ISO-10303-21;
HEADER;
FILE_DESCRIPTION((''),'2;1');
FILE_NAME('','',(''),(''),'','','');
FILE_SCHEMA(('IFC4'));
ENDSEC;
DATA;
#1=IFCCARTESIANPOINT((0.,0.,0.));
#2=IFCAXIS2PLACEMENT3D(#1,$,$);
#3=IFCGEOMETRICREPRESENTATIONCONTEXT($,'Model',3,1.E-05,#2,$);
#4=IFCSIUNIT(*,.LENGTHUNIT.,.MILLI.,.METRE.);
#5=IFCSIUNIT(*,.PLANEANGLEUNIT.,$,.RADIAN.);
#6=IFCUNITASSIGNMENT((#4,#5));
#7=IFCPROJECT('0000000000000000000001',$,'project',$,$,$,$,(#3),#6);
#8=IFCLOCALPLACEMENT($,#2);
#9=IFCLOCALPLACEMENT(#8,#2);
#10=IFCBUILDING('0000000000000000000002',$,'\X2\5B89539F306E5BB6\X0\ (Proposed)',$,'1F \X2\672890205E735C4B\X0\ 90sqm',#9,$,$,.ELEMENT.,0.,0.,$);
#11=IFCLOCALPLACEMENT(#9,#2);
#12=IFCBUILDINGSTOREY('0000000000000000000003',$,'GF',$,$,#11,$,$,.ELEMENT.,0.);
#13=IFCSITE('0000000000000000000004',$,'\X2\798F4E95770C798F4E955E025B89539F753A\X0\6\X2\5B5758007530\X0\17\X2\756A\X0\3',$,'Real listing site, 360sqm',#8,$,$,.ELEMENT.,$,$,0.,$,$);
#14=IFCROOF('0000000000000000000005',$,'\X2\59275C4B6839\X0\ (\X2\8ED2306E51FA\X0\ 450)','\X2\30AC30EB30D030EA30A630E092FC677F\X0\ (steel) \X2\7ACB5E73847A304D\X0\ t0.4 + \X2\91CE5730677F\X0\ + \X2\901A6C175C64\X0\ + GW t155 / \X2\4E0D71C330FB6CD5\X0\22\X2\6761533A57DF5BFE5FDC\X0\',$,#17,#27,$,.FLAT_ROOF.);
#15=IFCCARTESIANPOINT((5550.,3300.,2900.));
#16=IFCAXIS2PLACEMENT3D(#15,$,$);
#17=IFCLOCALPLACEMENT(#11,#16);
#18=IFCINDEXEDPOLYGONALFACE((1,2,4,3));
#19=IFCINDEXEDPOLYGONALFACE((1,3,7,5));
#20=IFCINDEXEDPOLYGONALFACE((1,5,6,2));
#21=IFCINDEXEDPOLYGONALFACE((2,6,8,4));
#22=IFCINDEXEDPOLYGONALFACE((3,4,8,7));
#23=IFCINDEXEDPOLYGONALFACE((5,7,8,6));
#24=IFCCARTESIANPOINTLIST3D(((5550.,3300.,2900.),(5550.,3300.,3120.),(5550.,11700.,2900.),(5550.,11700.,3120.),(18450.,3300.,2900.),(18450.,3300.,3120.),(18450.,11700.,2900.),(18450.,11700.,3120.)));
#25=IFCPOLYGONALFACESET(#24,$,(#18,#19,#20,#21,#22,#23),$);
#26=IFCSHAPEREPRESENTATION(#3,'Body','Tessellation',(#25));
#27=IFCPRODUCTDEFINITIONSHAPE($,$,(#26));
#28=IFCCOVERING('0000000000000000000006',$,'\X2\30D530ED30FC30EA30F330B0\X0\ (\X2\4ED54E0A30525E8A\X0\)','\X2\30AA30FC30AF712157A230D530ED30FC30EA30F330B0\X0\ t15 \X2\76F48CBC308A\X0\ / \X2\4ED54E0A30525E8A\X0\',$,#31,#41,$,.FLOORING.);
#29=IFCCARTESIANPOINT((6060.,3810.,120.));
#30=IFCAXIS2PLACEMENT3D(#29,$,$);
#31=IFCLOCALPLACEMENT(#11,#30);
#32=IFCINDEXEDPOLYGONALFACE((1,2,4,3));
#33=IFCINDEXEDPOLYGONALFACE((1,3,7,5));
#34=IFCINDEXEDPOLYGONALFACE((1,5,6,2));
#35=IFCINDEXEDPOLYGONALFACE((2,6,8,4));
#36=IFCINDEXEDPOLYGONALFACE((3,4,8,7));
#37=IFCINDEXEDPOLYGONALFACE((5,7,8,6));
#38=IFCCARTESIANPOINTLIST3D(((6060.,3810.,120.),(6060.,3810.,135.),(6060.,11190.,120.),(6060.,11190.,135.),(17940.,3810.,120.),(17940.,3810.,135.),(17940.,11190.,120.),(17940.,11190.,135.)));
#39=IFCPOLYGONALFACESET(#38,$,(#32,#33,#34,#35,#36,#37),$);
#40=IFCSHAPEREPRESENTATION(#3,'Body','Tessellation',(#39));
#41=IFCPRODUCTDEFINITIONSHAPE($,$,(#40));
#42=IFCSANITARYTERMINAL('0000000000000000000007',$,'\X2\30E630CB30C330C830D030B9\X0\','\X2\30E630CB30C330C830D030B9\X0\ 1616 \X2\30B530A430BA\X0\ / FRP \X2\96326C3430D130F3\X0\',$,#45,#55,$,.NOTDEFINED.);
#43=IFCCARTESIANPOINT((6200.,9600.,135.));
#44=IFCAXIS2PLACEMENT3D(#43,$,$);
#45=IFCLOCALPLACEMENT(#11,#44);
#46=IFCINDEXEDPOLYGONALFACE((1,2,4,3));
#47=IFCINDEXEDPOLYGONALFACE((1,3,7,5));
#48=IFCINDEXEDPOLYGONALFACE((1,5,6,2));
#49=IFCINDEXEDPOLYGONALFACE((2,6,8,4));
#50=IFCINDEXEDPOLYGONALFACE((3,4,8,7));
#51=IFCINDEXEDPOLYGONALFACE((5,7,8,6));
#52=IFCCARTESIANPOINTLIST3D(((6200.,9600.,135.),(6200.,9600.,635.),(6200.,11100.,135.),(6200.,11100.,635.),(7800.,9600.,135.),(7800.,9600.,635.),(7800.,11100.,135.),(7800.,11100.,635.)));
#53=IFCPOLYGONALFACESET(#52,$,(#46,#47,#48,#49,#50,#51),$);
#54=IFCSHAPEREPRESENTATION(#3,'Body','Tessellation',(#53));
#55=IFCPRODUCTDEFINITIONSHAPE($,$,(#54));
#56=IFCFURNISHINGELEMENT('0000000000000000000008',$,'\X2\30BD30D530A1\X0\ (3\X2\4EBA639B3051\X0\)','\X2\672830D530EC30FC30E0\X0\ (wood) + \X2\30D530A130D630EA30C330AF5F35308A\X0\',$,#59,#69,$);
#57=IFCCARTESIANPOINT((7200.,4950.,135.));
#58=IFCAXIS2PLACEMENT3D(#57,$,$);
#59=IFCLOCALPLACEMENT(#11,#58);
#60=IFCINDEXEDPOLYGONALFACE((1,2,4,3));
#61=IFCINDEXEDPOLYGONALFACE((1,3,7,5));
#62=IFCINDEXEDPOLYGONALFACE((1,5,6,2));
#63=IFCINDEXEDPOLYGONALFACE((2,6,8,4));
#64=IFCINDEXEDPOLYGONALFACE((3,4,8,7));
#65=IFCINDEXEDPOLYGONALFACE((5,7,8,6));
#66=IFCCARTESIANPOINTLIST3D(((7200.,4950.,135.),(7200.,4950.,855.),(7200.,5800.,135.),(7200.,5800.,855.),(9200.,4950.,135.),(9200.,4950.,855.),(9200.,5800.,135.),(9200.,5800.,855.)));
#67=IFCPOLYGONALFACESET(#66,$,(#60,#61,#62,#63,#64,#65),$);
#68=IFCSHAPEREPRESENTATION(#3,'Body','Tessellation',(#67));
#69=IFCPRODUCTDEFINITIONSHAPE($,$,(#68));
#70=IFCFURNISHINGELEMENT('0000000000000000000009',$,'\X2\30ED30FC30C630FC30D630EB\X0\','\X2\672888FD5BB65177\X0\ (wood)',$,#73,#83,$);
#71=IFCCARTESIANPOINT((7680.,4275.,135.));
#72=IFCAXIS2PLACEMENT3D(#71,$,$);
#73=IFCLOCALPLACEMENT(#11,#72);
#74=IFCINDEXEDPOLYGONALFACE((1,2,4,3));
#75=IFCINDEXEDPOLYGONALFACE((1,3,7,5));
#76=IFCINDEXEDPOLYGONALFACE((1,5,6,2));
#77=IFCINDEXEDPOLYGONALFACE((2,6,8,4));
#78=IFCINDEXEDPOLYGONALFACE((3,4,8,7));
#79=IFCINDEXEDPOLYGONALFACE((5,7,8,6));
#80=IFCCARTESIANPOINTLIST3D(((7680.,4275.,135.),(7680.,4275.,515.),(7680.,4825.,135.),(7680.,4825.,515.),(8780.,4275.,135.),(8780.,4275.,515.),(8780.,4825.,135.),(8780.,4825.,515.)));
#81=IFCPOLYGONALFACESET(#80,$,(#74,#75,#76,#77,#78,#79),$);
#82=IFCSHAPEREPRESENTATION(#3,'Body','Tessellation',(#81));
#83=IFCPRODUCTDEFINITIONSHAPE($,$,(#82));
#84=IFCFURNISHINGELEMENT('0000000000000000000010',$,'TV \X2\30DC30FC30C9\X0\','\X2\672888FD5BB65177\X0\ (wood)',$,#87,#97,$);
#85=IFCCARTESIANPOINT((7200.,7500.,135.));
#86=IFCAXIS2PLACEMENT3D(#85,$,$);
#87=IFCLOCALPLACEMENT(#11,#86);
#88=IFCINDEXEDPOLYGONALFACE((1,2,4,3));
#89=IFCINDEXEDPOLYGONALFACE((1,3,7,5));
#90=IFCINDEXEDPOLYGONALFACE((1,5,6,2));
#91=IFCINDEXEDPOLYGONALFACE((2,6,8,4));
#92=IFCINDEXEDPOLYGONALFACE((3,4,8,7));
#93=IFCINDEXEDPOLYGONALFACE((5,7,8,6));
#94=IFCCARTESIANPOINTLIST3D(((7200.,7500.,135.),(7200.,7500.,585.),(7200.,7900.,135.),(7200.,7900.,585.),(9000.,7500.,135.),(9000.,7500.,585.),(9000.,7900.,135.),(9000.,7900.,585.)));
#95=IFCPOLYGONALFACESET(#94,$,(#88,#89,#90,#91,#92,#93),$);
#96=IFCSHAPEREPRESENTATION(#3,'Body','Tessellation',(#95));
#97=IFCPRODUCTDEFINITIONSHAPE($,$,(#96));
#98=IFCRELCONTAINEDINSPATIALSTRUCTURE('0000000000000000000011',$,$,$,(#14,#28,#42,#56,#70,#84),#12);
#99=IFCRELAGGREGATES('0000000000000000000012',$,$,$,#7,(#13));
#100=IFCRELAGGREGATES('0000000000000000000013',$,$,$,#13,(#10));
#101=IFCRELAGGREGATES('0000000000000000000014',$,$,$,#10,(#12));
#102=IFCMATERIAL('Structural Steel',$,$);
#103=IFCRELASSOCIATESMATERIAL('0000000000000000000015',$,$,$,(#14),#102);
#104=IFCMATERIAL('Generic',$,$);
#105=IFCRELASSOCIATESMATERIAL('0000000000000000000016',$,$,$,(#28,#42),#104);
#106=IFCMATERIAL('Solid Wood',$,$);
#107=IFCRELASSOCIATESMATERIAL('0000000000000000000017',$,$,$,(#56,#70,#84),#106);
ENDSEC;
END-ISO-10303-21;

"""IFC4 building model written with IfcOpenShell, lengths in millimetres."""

from ifc_helpers import new_model, si_unit, frame, frame_2d, origin, place, context, project, spatial, rectangle, extrude, material, element, save


model = new_model("IFC4")

# Units and contexts
model_context = context("Model", 3, precision=1e-05, world=origin())
ifc_project = project(units=[si_unit("LENGTHUNIT", "METRE", prefix="MILLI"), si_unit("PLANEANGLEUNIT", "RADIAN")], contexts=[model_context])

# Site, building, storey
site_placement = place(None, origin())
site = spatial("IfcSite", under=ifc_project, at=site_placement, Name="福井県福井市安原町6字堀田17番3", ObjectType="Real listing site, 360sqm", CompositionType="ELEMENT", RefElevation=0.0)
building_placement = place(site_placement, origin())
building = spatial("IfcBuilding", under=site, at=building_placement, Name="安原の家 (Proposed)", ObjectType="1F 木造平屋 90sqm", CompositionType="ELEMENT", ElevationOfRefHeight=0.0, ElevationOfTerrain=0.0)
storey_placement = place(building_placement, origin())
storey = spatial("IfcBuildingStorey", under=building, at=storey_placement, Name="GF", CompositionType="ELEMENT", Elevation=0.0)

# Shared definitions
ifc_material_1 = material(Name="Solid Wood")

# Roof
ifc_material_2 = material(Name="Structural Steel")
roof_placement = place(storey_placement, frame((5550.0, 3300.0, 2900.0)))
element("IfcRoof", 1, at=roof_placement, inside=storey, material=ifc_material_2, Name="大屋根 (軒の出 450)", Description="ガルバリウム鋼板 (steel) 立平葺き t0.4 + 野地板 + 通気層 + GW t155 / 不燃・法22条区域対応", PredefinedType="FLAT_ROOF", context=model_context, shape_type="SweptSolid", body=[
    extrude(rectangle(XDim=12900.0, YDim=8400.0, at=frame_2d((6450.0, 4200.0))), frame((5550.0, 3300.0, 2900.0)), (0.0, 0.0, 1.0), 220.0),
])

# Covering
ifc_material_3 = material(Name="Generic")
covering_placement = place(storey_placement, frame((6060.0, 3810.0, 120.0)))
element("IfcCovering", 2, at=covering_placement, inside=storey, material=ifc_material_3, Name="フローリング (仕上げ床)", Description="オーク無垢フローリング t15 直貼り / 仕上げ床", PredefinedType="FLOORING", context=model_context, shape_type="SweptSolid", body=[
    extrude(rectangle(XDim=11880.0, YDim=7380.0, at=frame_2d((5940.0, 3690.0))), frame((6060.0, 3810.0, 120.0)), (0.0, 0.0, 1.0), 15.0),
])

# Sanitary terminal
sanitary_terminal_placement = place(storey_placement, frame((6200.0, 9600.0, 135.0)))
element("IfcSanitaryTerminal", 3, at=sanitary_terminal_placement, inside=storey, material=ifc_material_3, Name="ユニットバス", Description="ユニットバス 1616 サイズ / FRP 防水パン", PredefinedType="NOTDEFINED", context=model_context, shape_type="SweptSolid", body=[
    extrude(rectangle(XDim=1600.0, YDim=1500.0, at=frame_2d((800.0, 750.0))), frame((6200.0, 9600.0, 135.0)), (0.0, 0.0, 1.0), 500.0),
])

# Furnishing elements
furnishing_1_placement = place(storey_placement, frame((7200.0, 4950.0, 135.0)))
element("IfcFurnishingElement", 4, at=furnishing_1_placement, inside=storey, material=ifc_material_1, Name="ソファ (3人掛け)", Description="木フレーム (wood) + ファブリック張り", context=model_context, shape_type="SweptSolid", body=[
    extrude(rectangle(XDim=2000.0, YDim=850.0, at=frame_2d((1000.0, 425.0))), frame((7200.0, 4950.0, 135.0)), (0.0, 0.0, 1.0), 720.0),
])
furnishing_2_placement = place(storey_placement, frame((7680.0, 4275.0, 135.0)))
element("IfcFurnishingElement", 5, at=furnishing_2_placement, inside=storey, material=ifc_material_1, Name="ローテーブル", Description="木製家具 (wood)", context=model_context, shape_type="SweptSolid", body=[
    extrude(rectangle(XDim=1100.0, YDim=550.0, at=frame_2d((550.0, 275.0))), frame((7680.0, 4275.0, 135.0)), (0.0, 0.0, 1.0), 380.0),
])
furnishing_3_placement = place(storey_placement, frame((7200.0, 7500.0, 135.0)))
element("IfcFurnishingElement", 6, at=furnishing_3_placement, inside=storey, material=ifc_material_1, Name="TV ボード", Description="木製家具 (wood)", context=model_context, shape_type="SweptSolid", body=[
    extrude(rectangle(XDim=1800.0, YDim=400.0, at=frame_2d((900.0, 200.0))), frame((7200.0, 7500.0, 135.0)), (0.0, 0.0, 1.0), 450.0),
])

save(model, "model.ifc")
